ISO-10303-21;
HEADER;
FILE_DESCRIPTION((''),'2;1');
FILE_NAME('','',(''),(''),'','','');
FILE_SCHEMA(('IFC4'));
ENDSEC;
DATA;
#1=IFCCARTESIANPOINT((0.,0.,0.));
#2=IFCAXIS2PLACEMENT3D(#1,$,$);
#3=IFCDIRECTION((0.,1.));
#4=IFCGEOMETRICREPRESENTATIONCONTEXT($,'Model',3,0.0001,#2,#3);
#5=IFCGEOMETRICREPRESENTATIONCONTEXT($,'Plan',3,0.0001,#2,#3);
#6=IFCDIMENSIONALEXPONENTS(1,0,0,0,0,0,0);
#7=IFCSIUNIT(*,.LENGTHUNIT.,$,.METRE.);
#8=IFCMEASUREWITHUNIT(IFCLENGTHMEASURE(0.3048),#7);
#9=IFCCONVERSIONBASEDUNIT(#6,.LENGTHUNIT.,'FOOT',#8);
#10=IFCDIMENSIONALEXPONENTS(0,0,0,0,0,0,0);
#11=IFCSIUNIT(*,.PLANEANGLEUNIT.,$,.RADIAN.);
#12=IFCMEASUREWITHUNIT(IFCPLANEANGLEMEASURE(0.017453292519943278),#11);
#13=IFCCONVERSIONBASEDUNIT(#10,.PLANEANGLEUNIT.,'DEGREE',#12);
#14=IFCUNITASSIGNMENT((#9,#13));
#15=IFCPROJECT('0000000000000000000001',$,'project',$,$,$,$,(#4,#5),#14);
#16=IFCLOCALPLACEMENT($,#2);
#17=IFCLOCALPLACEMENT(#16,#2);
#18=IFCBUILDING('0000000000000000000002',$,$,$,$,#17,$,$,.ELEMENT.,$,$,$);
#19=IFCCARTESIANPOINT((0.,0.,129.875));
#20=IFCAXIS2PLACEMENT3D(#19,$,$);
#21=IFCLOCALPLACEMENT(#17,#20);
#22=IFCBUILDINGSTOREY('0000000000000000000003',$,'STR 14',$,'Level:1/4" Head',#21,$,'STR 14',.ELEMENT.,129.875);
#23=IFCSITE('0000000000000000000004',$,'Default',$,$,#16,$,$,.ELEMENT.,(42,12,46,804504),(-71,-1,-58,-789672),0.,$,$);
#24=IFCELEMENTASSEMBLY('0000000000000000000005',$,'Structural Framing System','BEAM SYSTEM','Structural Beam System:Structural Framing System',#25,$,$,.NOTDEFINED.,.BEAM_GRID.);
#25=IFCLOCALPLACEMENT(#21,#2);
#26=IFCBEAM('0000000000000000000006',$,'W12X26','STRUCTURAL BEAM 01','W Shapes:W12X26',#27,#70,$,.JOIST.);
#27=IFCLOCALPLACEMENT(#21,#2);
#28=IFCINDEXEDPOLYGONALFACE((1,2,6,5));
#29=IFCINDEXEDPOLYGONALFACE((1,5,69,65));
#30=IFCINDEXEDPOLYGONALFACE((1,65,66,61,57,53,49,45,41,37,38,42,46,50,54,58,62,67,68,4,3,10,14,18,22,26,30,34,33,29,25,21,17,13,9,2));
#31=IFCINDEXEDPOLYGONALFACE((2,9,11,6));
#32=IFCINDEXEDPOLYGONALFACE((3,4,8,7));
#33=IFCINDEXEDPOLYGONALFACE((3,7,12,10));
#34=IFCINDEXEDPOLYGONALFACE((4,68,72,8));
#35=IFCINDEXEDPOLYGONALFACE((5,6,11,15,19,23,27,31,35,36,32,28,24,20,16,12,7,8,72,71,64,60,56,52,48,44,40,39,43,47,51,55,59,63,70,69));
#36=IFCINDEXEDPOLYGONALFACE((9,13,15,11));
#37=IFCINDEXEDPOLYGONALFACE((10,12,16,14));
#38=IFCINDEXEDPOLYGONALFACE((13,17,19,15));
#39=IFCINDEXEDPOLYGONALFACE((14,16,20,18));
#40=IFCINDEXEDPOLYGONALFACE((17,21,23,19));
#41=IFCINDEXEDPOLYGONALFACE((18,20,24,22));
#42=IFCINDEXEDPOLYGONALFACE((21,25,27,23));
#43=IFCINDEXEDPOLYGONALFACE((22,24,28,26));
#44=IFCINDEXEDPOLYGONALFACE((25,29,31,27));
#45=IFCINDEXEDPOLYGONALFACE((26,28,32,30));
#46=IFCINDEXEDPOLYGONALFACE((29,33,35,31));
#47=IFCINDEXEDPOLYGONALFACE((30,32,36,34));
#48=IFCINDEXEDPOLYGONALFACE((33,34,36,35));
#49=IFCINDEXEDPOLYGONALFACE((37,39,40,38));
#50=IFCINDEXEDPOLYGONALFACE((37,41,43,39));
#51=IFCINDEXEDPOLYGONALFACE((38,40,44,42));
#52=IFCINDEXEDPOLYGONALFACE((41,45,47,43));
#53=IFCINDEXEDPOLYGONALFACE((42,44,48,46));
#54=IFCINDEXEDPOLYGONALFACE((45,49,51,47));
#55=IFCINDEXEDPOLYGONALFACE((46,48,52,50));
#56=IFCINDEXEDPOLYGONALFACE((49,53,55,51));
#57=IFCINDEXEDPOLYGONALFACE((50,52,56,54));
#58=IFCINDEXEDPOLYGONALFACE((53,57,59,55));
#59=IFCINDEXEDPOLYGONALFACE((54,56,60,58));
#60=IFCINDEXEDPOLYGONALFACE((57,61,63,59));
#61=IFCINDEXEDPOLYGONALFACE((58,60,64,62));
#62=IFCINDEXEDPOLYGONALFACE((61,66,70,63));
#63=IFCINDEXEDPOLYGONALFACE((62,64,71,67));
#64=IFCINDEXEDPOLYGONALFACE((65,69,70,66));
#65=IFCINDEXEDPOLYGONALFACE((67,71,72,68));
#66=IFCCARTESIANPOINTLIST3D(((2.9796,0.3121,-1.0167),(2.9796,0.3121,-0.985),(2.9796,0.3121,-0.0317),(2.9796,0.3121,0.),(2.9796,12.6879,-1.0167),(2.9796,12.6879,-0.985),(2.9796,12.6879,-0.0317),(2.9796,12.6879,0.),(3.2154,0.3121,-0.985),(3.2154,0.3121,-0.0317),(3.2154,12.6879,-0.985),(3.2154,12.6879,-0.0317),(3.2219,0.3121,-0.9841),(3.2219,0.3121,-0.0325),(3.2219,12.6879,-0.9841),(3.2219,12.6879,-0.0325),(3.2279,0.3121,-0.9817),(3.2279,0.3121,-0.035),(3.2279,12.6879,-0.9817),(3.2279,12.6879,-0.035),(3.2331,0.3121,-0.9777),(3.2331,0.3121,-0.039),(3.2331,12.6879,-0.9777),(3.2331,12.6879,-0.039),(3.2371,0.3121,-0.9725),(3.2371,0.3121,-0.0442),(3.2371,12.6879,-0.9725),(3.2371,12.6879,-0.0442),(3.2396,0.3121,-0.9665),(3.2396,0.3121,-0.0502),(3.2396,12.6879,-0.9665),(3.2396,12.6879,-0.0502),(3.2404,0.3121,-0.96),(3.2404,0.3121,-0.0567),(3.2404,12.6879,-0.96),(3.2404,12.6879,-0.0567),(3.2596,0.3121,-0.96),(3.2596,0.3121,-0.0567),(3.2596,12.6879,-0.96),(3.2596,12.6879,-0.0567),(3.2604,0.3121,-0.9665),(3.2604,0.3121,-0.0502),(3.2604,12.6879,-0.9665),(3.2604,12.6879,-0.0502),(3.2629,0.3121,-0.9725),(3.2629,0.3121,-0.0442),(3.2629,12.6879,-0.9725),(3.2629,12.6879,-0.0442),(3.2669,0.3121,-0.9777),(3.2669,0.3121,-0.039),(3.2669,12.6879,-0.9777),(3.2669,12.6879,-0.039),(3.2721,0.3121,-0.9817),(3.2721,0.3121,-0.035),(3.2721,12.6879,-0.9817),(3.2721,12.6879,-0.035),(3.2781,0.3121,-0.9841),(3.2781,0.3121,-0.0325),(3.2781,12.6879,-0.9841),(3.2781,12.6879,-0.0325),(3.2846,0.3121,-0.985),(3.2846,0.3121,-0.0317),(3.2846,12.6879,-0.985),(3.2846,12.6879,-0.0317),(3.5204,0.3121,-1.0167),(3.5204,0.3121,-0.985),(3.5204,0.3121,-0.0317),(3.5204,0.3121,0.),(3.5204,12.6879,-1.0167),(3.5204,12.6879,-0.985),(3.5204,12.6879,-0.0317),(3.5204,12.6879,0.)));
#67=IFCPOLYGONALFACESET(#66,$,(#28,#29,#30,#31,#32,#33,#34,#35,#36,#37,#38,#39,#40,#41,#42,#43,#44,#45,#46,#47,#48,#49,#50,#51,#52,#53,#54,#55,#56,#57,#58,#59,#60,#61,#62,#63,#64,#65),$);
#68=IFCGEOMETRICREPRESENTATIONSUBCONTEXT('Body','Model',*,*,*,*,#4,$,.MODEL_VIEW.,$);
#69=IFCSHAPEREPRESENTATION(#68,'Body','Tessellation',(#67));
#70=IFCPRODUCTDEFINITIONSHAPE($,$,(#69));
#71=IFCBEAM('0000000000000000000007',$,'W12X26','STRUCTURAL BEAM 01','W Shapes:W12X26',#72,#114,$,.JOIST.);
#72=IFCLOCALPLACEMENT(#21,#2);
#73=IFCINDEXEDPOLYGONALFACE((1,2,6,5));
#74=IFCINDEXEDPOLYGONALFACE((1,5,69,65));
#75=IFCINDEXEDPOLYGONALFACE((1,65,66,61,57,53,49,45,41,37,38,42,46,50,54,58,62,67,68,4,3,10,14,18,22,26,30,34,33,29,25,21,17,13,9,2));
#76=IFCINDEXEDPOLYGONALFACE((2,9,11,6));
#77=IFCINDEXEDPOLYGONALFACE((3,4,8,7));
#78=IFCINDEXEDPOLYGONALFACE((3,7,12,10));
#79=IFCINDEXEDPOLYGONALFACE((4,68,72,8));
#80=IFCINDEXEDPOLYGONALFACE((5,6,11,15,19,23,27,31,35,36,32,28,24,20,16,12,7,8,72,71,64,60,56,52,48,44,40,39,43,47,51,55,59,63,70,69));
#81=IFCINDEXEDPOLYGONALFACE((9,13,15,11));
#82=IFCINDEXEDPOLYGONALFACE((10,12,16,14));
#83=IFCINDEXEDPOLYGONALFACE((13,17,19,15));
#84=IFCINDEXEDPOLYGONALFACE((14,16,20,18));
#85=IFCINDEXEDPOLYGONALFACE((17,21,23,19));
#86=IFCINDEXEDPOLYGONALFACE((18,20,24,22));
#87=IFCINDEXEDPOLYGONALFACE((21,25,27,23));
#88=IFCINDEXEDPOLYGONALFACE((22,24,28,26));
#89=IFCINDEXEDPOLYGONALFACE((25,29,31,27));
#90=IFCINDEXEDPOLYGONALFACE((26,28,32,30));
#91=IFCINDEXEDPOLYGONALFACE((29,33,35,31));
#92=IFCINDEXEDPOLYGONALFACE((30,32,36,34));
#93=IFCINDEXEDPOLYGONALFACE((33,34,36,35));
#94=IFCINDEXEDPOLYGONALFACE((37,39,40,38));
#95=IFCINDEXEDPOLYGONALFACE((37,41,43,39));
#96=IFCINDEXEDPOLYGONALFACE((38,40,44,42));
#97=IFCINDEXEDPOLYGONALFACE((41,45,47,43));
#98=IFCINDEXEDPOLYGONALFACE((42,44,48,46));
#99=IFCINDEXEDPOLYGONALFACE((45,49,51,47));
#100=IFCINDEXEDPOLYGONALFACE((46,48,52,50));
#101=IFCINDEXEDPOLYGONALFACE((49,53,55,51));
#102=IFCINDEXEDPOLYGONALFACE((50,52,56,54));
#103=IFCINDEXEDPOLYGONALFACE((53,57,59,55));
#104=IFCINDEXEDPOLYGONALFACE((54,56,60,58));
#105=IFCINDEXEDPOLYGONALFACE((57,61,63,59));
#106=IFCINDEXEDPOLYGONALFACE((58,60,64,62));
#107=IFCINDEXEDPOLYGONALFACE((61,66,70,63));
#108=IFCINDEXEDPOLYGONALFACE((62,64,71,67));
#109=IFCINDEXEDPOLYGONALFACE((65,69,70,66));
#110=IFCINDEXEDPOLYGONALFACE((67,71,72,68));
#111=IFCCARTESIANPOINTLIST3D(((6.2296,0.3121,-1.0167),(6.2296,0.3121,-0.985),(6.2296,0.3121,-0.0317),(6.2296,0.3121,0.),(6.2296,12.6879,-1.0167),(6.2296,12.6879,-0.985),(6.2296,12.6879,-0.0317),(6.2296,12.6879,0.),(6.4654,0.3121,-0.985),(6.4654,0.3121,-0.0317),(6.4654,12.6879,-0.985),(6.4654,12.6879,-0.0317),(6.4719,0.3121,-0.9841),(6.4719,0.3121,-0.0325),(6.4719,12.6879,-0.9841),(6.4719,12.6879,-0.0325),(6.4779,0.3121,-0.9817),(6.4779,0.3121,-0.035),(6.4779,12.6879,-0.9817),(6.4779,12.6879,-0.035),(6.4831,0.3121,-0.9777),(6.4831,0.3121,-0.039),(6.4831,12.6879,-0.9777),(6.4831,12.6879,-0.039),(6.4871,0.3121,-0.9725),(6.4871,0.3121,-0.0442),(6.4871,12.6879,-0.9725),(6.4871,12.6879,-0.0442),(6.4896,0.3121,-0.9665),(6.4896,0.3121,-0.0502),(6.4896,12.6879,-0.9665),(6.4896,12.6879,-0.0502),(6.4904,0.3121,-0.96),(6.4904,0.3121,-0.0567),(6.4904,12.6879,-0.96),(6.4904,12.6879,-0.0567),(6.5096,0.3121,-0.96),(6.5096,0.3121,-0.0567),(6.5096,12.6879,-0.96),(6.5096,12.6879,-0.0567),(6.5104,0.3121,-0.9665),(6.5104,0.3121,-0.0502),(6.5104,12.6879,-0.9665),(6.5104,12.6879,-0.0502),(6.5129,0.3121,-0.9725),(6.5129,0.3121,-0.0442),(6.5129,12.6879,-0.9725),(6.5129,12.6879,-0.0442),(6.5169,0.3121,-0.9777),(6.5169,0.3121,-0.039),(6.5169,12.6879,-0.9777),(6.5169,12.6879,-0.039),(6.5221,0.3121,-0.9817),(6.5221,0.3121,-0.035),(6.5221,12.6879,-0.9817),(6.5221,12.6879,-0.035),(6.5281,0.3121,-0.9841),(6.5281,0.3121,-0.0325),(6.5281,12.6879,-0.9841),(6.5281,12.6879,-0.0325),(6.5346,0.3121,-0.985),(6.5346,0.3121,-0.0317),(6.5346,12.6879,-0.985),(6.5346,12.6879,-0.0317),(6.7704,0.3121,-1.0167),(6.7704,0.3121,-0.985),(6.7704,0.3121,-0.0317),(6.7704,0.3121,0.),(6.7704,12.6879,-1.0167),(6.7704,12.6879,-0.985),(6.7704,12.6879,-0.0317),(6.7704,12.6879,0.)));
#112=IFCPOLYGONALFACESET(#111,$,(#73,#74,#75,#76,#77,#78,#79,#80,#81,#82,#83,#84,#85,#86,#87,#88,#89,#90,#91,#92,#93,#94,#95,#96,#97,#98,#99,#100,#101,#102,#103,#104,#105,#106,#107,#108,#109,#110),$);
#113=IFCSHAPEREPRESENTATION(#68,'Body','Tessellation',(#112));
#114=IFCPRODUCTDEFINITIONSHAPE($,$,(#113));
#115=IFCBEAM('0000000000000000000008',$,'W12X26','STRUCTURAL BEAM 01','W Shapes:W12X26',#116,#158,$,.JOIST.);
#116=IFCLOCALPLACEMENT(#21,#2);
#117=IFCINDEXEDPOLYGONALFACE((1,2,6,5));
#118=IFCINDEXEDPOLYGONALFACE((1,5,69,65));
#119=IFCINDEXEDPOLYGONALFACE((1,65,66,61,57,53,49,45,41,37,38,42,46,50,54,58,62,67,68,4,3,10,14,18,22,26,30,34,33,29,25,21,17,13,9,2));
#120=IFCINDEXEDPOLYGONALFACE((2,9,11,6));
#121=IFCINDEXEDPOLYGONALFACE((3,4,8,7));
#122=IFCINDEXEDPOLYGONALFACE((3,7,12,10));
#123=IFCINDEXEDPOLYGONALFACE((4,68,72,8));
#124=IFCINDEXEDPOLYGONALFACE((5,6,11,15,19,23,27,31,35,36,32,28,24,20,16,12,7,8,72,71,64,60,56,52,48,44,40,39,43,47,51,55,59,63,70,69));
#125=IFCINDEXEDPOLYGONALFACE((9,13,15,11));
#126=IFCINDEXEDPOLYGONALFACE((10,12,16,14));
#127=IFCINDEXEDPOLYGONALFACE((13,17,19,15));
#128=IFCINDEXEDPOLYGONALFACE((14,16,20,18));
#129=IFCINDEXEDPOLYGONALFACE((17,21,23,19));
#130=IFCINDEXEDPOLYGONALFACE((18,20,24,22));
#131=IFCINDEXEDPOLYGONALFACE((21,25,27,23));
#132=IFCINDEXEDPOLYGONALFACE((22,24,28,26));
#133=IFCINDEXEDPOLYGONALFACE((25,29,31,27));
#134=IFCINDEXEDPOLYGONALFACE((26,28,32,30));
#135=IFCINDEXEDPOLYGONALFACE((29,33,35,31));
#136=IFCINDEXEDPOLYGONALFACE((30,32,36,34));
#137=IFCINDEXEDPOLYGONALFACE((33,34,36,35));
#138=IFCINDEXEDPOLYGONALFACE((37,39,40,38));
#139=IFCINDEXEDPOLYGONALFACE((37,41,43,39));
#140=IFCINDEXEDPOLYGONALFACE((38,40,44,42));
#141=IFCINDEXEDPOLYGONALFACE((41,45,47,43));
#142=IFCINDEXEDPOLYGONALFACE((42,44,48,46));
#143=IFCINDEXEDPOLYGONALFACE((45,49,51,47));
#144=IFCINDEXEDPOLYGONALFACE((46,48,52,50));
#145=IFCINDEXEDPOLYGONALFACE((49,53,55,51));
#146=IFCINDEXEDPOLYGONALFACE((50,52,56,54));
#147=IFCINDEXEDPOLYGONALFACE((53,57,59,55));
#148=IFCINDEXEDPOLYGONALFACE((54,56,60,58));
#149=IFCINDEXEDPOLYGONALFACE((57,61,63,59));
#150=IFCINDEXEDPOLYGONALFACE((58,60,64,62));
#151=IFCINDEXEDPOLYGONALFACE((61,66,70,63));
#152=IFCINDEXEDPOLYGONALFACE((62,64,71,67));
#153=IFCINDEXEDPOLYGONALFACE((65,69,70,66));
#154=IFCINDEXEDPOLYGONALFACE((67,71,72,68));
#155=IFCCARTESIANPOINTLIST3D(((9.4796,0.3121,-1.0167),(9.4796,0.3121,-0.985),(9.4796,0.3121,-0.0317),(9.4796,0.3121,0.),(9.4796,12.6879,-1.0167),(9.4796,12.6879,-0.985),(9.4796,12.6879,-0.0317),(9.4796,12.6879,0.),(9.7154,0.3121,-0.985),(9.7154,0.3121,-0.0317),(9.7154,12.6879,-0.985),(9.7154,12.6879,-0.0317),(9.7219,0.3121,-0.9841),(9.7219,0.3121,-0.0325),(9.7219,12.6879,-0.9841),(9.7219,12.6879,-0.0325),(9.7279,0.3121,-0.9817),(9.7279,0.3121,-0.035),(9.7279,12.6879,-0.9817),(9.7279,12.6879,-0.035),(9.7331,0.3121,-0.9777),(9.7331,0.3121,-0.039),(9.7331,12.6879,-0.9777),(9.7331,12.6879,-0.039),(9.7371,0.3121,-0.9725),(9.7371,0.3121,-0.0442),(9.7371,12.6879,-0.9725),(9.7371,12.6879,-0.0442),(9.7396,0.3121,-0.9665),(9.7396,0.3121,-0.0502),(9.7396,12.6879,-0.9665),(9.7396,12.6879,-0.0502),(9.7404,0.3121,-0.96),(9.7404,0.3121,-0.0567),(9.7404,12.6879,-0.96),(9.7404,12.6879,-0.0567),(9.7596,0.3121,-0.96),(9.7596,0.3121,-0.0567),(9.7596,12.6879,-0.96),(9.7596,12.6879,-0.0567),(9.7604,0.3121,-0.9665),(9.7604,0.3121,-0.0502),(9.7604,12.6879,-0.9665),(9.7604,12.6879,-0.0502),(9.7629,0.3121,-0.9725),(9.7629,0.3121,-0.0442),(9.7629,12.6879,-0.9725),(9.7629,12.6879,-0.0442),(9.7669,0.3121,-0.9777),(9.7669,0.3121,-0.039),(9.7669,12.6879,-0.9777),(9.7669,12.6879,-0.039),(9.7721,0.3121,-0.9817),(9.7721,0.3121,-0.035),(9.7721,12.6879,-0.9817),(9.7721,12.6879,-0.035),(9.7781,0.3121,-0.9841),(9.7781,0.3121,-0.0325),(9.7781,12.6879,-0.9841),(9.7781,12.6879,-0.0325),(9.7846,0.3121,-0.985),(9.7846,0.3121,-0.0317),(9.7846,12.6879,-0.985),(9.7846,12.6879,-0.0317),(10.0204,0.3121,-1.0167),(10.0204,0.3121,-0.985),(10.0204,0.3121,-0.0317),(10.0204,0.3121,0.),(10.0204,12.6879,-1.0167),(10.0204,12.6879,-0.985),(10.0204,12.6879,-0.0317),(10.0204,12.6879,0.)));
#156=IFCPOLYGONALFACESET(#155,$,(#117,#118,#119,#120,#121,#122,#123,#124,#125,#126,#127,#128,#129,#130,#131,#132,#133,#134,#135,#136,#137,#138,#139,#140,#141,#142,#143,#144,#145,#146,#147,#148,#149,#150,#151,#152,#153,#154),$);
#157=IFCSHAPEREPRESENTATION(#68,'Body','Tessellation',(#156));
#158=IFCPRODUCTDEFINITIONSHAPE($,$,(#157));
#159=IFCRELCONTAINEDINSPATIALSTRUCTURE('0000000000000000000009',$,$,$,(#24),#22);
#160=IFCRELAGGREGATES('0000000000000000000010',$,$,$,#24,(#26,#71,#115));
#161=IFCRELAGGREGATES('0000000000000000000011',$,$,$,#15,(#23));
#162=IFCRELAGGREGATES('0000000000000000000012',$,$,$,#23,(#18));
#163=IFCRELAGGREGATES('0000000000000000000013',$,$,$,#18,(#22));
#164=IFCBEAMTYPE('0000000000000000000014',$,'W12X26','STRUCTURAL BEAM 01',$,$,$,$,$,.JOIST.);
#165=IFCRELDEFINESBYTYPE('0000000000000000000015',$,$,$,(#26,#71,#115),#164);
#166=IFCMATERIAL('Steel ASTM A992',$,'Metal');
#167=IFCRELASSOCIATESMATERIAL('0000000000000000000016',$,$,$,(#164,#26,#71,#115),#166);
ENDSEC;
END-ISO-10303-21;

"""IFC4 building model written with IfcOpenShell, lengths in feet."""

from ifc_helpers import new_model, entity, si_unit, converted_unit, direction, frame, origin, place, context, subcontext, project, spatial, line, arc, indexed_curve, outline, extrude, source, transform, mapped, material, type_object, type_shapes, element, aggregate, save


model = new_model("IFC4")

# Units and contexts
model_context = context("Model", 3, precision=0.0001, world=origin(), true_north=direction((0.0, 1.0)))
plan_context = context("Plan", 3, precision=0.0001, world=origin(), true_north=direction((0.0, 1.0)))
body_context = subcontext(model_context, "Body", "Model", "MODEL_VIEW")
ifc_project = project(units=[converted_unit("LENGTHUNIT", "FOOT", entity("IfcLengthMeasure", 0.3048), si_unit("LENGTHUNIT", "METRE"), dimensions=[1, 0, 0, 0, 0, 0, 0]), converted_unit("PLANEANGLEUNIT", "DEGREE", entity("IfcPlaneAngleMeasure", 0.017453292519943278), si_unit("PLANEANGLEUNIT", "RADIAN"), dimensions=[0, 0, 0, 0, 0, 0, 0])], contexts=[model_context, plan_context])

# Site, building, storey
site_placement = place(None, origin())
site = spatial("IfcSite", under=ifc_project, at=site_placement, Name="Default", CompositionType="ELEMENT", RefLatitude=(42, 12, 46, 804504), RefLongitude=(-71, -1, -58, -789672), RefElevation=0.0)
building_placement = place(site_placement, origin())
building = spatial("IfcBuilding", under=site, at=building_placement, CompositionType="ELEMENT")
storey_placement = place(building_placement, frame((0.0, 0.0, 129.875)))
storey = spatial("IfcBuildingStorey", under=building, at=storey_placement, Name="STR 14", ObjectType="Level:1/4\" Head", LongName="STR 14", CompositionType="ELEMENT", Elevation=129.875)

# Shared definitions
ifc_material = material(Name="Steel ASTM A992", Category="Metal")

# Element assembly, beams
assembly_1_placement = place(storey_placement, origin())
assembly_1 = element("IfcElementAssembly", 1, at=assembly_1_placement, inside=storey, Name="Structural Framing System", Description="BEAM SYSTEM", ObjectType="Structural Beam System:Structural Framing System", AssemblyPlace="NOTDEFINED", PredefinedType="BEAM_GRID")
beam_type_1 = type_object("IfcBeamType", Name="W12X26", Description="STRUCTURAL BEAM 01", PredefinedType="JOIST", material=ifc_material)
shared_shape_1 = source(origin(), body_context, "Body", "SweptSolid", [
    extrude(outline(indexed_curve([(-0.2704, -0.4767), (-0.2704, -0.5083), (0.2704, -0.5083), (0.2704, -0.4767), (0.0346, -0.4767), (0.0169, -0.4693), (0.0096, -0.4517), (0.0096, 0.4517), (0.0169, 0.4693), (0.0346, 0.4767), (0.2704, 0.4767), (0.2704, 0.5083), (-0.2704, 0.5083), (-0.2704, 0.4767), (-0.0346, 0.4767), (-0.0169, 0.4693), (-0.0096, 0.4517), (-0.0096, -0.4517), (-0.0169, -0.4693), (-0.0346, -0.4767)], segments=[line(1, 2, 3, 4, 5), arc(5, 6, 7), line(7, 8), arc(8, 9, 10), line(10, 11, 12, 13, 14, 15), arc(15, 16, 17), line(17, 18), arc(18, 19, 20), line(20, 1)], self_intersect=False)), frame((-6.1879, 0.0, 0.0), z_axis=(-1.0, 0.0, 0.0), x_axis=(0.0, -1.0, 0.0)), (0.0, 0.0, -1.0), 12.3758),
])
type_shapes(beam_type_1, [shared_shape_1])
beam_1_placement = place(assembly_1_placement, frame((3.25, 6.5, -0.5083), z_axis=(0.0, 0.0, 1.0), x_axis=(0.0, 1.0, 0.0)))
beam_1 = element("IfcBeam", 2, at=beam_1_placement, type_object=beam_type_1, material=ifc_material, Name="W12X26", Description="STRUCTURAL BEAM 01", ObjectType="W Shapes:W12X26", PredefinedType="JOIST", context=body_context, shape_type="MappedRepresentation", body=[
    mapped(shared_shape_1, transform((0.0, 0.0, 0.0), scale=1.0)),
])
beam_2_placement = place(assembly_1_placement, frame((6.5, 6.5, -0.5083), z_axis=(0.0, 0.0, 1.0), x_axis=(0.0, 1.0, 0.0)))
beam_2 = element("IfcBeam", 3, at=beam_2_placement, type_object=beam_type_1, material=ifc_material, Name="W12X26", Description="STRUCTURAL BEAM 01", ObjectType="W Shapes:W12X26", PredefinedType="JOIST", context=body_context, shape_type="MappedRepresentation", body=[
    mapped(shared_shape_1, transform((0.0, 0.0, 0.0), scale=1.0)),
])
beam_3_placement = place(assembly_1_placement, frame((9.75, 6.5, -0.5083), z_axis=(0.0, 0.0, 1.0), x_axis=(0.0, 1.0, 0.0)))
beam_3 = element("IfcBeam", 4, at=beam_3_placement, type_object=beam_type_1, material=ifc_material, Name="W12X26", Description="STRUCTURAL BEAM 01", ObjectType="W Shapes:W12X26", PredefinedType="JOIST", context=body_context, shape_type="MappedRepresentation", body=[
    mapped(shared_shape_1, transform((0.0, 0.0, 0.0), scale=1.0)),
])
aggregate(assembly_1, [beam_1, beam_2, beam_3])

save(model, "model.ifc")
